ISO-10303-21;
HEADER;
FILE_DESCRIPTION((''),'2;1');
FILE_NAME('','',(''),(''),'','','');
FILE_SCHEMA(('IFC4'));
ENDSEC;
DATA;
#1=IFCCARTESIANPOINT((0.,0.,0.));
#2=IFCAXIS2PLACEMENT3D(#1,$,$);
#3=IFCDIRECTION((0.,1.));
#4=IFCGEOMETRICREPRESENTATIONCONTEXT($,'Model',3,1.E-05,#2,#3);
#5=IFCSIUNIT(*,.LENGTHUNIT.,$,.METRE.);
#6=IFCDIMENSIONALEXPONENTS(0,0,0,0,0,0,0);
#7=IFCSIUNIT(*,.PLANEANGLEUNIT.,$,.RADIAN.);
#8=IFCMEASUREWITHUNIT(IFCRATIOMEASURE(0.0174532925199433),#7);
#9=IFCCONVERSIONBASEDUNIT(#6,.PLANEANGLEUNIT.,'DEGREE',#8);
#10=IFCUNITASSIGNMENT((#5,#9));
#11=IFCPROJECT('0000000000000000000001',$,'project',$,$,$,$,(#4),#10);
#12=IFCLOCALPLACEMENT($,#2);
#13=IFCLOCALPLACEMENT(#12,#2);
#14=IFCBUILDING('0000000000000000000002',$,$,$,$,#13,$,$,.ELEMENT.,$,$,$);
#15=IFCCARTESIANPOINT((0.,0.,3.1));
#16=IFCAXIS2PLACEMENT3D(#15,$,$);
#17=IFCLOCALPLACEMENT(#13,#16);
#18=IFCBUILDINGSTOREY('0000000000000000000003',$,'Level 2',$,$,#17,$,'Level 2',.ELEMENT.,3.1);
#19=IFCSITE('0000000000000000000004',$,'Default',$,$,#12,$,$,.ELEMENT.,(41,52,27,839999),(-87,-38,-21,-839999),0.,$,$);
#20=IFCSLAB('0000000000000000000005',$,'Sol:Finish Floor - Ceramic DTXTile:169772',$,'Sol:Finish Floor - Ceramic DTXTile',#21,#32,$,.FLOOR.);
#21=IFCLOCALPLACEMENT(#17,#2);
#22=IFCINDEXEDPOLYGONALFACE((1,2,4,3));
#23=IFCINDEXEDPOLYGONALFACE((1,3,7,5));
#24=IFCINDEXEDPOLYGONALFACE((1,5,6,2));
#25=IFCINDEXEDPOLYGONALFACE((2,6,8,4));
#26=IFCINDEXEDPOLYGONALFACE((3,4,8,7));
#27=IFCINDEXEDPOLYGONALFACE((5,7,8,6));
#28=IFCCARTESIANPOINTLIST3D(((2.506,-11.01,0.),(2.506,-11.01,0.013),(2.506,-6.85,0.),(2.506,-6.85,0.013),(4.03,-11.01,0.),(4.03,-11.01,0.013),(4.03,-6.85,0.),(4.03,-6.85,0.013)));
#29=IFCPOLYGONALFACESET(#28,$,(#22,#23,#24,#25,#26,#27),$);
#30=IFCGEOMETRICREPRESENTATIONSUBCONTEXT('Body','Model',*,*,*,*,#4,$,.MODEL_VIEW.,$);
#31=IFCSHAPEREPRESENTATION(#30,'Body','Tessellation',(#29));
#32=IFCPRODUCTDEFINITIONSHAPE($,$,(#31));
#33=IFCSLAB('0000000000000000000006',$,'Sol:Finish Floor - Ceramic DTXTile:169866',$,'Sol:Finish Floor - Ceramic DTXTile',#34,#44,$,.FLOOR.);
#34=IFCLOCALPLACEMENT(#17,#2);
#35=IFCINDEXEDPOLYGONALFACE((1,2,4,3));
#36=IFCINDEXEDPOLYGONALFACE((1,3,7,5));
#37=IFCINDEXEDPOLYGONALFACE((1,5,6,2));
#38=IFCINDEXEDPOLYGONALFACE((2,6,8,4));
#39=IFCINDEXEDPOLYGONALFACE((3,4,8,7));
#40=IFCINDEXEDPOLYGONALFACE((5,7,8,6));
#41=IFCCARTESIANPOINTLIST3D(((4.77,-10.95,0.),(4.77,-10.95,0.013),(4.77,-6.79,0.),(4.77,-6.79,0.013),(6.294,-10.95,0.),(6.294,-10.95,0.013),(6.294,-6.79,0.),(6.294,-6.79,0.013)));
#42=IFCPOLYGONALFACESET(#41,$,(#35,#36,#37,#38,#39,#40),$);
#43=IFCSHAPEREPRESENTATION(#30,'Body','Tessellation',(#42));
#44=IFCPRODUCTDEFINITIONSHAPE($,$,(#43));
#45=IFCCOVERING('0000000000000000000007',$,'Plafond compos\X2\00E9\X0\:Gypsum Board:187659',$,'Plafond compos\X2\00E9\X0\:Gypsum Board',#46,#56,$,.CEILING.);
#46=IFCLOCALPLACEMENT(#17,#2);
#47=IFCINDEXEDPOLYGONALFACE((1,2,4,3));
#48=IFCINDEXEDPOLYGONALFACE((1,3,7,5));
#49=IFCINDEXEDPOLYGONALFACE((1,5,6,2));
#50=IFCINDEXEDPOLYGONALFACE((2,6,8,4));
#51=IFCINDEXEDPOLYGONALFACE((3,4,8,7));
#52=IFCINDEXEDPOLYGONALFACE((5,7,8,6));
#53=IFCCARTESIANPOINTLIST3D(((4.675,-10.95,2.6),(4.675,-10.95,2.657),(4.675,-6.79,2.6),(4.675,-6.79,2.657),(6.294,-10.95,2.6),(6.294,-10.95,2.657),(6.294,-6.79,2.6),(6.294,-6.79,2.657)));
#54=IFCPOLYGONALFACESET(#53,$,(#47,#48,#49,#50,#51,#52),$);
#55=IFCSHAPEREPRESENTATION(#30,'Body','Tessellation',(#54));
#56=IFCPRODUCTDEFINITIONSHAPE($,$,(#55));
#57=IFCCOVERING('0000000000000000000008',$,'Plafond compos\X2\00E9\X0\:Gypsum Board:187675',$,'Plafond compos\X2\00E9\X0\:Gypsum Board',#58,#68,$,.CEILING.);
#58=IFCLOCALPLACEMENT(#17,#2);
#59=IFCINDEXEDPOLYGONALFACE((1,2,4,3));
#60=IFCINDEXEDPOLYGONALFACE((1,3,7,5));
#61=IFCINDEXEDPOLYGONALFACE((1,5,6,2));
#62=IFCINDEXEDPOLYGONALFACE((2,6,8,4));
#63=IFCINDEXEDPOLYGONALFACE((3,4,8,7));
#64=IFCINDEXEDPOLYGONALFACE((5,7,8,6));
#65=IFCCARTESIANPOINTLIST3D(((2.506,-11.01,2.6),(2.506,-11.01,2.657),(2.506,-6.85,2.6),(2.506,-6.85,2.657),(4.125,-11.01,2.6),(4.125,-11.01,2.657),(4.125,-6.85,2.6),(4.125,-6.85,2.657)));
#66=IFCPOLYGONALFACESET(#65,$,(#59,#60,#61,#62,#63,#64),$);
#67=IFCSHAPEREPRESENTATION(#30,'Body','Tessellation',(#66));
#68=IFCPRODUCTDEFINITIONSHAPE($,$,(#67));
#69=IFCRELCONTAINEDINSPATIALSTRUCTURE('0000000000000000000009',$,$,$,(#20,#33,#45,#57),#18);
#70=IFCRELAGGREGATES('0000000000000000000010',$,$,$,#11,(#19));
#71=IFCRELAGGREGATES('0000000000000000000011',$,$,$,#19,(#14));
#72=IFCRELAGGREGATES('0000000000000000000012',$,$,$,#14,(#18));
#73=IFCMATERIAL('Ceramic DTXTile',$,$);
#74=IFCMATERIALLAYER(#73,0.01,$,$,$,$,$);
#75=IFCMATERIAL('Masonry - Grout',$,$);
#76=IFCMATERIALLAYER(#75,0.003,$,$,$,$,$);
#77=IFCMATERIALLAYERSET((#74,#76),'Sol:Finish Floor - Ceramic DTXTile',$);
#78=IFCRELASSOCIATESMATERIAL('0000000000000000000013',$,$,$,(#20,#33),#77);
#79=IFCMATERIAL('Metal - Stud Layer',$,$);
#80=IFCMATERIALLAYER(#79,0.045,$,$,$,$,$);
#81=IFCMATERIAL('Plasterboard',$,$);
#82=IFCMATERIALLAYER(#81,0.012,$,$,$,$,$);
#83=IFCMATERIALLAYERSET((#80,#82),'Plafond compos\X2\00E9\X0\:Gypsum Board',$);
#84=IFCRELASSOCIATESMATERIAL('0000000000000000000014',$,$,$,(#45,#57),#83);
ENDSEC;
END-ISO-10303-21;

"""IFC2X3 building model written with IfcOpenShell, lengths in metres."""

from ifc_helpers import new_model, entity, si_unit, converted_unit, direction, frame, frame_2d, origin, place, context, subcontext, project, spatial, rectangle, extrude, material, layer, layer_set, layer_usage, element, save


model = new_model("IFC2X3")

# Units and contexts
model_context = context("Model", 3, precision=1e-05, world=origin(), true_north=direction((0.0, 1.0)))
body_context = subcontext(model_context, "Body", "Model", "MODEL_VIEW")
ifc_project = project(units=[si_unit("LENGTHUNIT", "METRE"), converted_unit("PLANEANGLEUNIT", "DEGREE", entity("IfcRatioMeasure", 0.0174532925199433), si_unit("PLANEANGLEUNIT", "RADIAN"), dimensions=[0, 0, 0, 0, 0, 0, 0])], contexts=[model_context])

# Site, building, storey
site_placement = place(None, origin())
site = spatial("IfcSite", under=ifc_project, at=site_placement, Name="Default", CompositionType="ELEMENT", RefLatitude=(41, 52, 27, 839999), RefLongitude=(-87, -38, -21, -839999), RefElevation=0.0)
building_placement = place(site_placement, origin())
building = spatial("IfcBuilding", under=site, at=building_placement, CompositionType="ELEMENT")
storey_placement = place(building_placement, frame((0.0, 0.0, 3.1)))
storey = spatial("IfcBuildingStorey", under=building, at=storey_placement, Name="Level 2", LongName="Level 2", CompositionType="ELEMENT", Elevation=3.1)

# Slabs
ifc_material_1 = material(Name="Ceramic DTXTile")
ifc_layer_1 = layer(ifc_material_1, 0.01)
ifc_material_2 = material(Name="Masonry - Grout")
ifc_layer_2 = layer(ifc_material_2, 0.003)
ifc_layer_set_1 = layer_set([ifc_layer_1, ifc_layer_2], Name="Sol:Finish Floor - Ceramic DTXTile")
ifc_layer_usage_1 = layer_usage(ifc_layer_set_1, "AXIS3", "POSITIVE", 0.0)
slab_1_placement = place(storey_placement, origin())
element("IfcSlab", 1, at=slab_1_placement, inside=storey, material=ifc_layer_usage_1, Name="Sol:Finish Floor - Ceramic DTXTile:169772", ObjectType="Sol:Finish Floor - Ceramic DTXTile", PredefinedType="FLOOR", context=body_context, shape_type="SweptSolid", body=[
    extrude(rectangle(XDim=4.16, YDim=1.524, at=frame_2d((0.0, 0.0), x_axis=(1.0, 0.0))), frame((3.268, -8.93, 0.013), z_axis=(0.0, 0.0, -1.0), x_axis=(0.0, 1.0, 0.0)), (0.0, 0.0, 1.0), 0.013),
])
ifc_layer_usage_2 = layer_usage(ifc_layer_set_1, "AXIS3", "POSITIVE", 0.0)
slab_2_placement = place(storey_placement, origin())
element("IfcSlab", 2, at=slab_2_placement, inside=storey, material=ifc_layer_usage_2, Name="Sol:Finish Floor - Ceramic DTXTile:169866", ObjectType="Sol:Finish Floor - Ceramic DTXTile", PredefinedType="FLOOR", context=body_context, shape_type="SweptSolid", body=[
    extrude(rectangle(XDim=4.16, YDim=1.524, at=frame_2d((0.0, 0.0), x_axis=(1.0, 0.0))), frame((5.532, -8.87, 0.013), z_axis=(0.0, 0.0, -1.0), x_axis=(0.0, 1.0, 0.0)), (0.0, 0.0, 1.0), 0.013),
])

# Shared definitions
ifc_material_3 = material(Name="Metal - Stud Layer")
ifc_material_4 = material(Name="Plasterboard")

# Shared definitions
ifc_layer_3 = layer(ifc_material_3, 0.045)
ifc_layer_4 = layer(ifc_material_4, 0.012)
ifc_layer_set_2 = layer_set([ifc_layer_3, ifc_layer_4], Name="Plafond composé:Gypsum Board")

# Coverings
ifc_layer_usage_3 = layer_usage(ifc_layer_set_2, "AXIS3", "NEGATIVE", 0.0)
covering_1_placement = place(storey_placement, origin())
element("IfcCovering", 3, at=covering_1_placement, inside=storey, material=ifc_layer_usage_3, Name="Plafond composé:Gypsum Board:187659", ObjectType="Plafond composé:Gypsum Board", PredefinedType="CEILING", context=body_context, shape_type="SweptSolid", body=[
    extrude(rectangle(XDim=1.619, YDim=4.16, at=frame_2d((0.0, 0.0), x_axis=(1.0, 0.0))), frame((5.4845, -8.87, 2.6)), (0.0, 0.0, 1.0), 0.057),
])
ifc_layer_usage_4 = layer_usage(ifc_layer_set_2, "AXIS3", "NEGATIVE", 0.0)
covering_2_placement = place(storey_placement, origin())
element("IfcCovering", 4, at=covering_2_placement, inside=storey, material=ifc_layer_usage_4, Name="Plafond composé:Gypsum Board:187675", ObjectType="Plafond composé:Gypsum Board", PredefinedType="CEILING", context=body_context, shape_type="SweptSolid", body=[
    extrude(rectangle(XDim=1.619, YDim=4.16, at=frame_2d((0.0, 0.0), x_axis=(1.0, 0.0))), frame((3.3155, -8.93, 2.6), z_axis=(0.0, 0.0, 1.0), x_axis=(-1.0, 0.0, 0.0)), (0.0, 0.0, 1.0), 0.057),
])

save(model, "model.ifc")
